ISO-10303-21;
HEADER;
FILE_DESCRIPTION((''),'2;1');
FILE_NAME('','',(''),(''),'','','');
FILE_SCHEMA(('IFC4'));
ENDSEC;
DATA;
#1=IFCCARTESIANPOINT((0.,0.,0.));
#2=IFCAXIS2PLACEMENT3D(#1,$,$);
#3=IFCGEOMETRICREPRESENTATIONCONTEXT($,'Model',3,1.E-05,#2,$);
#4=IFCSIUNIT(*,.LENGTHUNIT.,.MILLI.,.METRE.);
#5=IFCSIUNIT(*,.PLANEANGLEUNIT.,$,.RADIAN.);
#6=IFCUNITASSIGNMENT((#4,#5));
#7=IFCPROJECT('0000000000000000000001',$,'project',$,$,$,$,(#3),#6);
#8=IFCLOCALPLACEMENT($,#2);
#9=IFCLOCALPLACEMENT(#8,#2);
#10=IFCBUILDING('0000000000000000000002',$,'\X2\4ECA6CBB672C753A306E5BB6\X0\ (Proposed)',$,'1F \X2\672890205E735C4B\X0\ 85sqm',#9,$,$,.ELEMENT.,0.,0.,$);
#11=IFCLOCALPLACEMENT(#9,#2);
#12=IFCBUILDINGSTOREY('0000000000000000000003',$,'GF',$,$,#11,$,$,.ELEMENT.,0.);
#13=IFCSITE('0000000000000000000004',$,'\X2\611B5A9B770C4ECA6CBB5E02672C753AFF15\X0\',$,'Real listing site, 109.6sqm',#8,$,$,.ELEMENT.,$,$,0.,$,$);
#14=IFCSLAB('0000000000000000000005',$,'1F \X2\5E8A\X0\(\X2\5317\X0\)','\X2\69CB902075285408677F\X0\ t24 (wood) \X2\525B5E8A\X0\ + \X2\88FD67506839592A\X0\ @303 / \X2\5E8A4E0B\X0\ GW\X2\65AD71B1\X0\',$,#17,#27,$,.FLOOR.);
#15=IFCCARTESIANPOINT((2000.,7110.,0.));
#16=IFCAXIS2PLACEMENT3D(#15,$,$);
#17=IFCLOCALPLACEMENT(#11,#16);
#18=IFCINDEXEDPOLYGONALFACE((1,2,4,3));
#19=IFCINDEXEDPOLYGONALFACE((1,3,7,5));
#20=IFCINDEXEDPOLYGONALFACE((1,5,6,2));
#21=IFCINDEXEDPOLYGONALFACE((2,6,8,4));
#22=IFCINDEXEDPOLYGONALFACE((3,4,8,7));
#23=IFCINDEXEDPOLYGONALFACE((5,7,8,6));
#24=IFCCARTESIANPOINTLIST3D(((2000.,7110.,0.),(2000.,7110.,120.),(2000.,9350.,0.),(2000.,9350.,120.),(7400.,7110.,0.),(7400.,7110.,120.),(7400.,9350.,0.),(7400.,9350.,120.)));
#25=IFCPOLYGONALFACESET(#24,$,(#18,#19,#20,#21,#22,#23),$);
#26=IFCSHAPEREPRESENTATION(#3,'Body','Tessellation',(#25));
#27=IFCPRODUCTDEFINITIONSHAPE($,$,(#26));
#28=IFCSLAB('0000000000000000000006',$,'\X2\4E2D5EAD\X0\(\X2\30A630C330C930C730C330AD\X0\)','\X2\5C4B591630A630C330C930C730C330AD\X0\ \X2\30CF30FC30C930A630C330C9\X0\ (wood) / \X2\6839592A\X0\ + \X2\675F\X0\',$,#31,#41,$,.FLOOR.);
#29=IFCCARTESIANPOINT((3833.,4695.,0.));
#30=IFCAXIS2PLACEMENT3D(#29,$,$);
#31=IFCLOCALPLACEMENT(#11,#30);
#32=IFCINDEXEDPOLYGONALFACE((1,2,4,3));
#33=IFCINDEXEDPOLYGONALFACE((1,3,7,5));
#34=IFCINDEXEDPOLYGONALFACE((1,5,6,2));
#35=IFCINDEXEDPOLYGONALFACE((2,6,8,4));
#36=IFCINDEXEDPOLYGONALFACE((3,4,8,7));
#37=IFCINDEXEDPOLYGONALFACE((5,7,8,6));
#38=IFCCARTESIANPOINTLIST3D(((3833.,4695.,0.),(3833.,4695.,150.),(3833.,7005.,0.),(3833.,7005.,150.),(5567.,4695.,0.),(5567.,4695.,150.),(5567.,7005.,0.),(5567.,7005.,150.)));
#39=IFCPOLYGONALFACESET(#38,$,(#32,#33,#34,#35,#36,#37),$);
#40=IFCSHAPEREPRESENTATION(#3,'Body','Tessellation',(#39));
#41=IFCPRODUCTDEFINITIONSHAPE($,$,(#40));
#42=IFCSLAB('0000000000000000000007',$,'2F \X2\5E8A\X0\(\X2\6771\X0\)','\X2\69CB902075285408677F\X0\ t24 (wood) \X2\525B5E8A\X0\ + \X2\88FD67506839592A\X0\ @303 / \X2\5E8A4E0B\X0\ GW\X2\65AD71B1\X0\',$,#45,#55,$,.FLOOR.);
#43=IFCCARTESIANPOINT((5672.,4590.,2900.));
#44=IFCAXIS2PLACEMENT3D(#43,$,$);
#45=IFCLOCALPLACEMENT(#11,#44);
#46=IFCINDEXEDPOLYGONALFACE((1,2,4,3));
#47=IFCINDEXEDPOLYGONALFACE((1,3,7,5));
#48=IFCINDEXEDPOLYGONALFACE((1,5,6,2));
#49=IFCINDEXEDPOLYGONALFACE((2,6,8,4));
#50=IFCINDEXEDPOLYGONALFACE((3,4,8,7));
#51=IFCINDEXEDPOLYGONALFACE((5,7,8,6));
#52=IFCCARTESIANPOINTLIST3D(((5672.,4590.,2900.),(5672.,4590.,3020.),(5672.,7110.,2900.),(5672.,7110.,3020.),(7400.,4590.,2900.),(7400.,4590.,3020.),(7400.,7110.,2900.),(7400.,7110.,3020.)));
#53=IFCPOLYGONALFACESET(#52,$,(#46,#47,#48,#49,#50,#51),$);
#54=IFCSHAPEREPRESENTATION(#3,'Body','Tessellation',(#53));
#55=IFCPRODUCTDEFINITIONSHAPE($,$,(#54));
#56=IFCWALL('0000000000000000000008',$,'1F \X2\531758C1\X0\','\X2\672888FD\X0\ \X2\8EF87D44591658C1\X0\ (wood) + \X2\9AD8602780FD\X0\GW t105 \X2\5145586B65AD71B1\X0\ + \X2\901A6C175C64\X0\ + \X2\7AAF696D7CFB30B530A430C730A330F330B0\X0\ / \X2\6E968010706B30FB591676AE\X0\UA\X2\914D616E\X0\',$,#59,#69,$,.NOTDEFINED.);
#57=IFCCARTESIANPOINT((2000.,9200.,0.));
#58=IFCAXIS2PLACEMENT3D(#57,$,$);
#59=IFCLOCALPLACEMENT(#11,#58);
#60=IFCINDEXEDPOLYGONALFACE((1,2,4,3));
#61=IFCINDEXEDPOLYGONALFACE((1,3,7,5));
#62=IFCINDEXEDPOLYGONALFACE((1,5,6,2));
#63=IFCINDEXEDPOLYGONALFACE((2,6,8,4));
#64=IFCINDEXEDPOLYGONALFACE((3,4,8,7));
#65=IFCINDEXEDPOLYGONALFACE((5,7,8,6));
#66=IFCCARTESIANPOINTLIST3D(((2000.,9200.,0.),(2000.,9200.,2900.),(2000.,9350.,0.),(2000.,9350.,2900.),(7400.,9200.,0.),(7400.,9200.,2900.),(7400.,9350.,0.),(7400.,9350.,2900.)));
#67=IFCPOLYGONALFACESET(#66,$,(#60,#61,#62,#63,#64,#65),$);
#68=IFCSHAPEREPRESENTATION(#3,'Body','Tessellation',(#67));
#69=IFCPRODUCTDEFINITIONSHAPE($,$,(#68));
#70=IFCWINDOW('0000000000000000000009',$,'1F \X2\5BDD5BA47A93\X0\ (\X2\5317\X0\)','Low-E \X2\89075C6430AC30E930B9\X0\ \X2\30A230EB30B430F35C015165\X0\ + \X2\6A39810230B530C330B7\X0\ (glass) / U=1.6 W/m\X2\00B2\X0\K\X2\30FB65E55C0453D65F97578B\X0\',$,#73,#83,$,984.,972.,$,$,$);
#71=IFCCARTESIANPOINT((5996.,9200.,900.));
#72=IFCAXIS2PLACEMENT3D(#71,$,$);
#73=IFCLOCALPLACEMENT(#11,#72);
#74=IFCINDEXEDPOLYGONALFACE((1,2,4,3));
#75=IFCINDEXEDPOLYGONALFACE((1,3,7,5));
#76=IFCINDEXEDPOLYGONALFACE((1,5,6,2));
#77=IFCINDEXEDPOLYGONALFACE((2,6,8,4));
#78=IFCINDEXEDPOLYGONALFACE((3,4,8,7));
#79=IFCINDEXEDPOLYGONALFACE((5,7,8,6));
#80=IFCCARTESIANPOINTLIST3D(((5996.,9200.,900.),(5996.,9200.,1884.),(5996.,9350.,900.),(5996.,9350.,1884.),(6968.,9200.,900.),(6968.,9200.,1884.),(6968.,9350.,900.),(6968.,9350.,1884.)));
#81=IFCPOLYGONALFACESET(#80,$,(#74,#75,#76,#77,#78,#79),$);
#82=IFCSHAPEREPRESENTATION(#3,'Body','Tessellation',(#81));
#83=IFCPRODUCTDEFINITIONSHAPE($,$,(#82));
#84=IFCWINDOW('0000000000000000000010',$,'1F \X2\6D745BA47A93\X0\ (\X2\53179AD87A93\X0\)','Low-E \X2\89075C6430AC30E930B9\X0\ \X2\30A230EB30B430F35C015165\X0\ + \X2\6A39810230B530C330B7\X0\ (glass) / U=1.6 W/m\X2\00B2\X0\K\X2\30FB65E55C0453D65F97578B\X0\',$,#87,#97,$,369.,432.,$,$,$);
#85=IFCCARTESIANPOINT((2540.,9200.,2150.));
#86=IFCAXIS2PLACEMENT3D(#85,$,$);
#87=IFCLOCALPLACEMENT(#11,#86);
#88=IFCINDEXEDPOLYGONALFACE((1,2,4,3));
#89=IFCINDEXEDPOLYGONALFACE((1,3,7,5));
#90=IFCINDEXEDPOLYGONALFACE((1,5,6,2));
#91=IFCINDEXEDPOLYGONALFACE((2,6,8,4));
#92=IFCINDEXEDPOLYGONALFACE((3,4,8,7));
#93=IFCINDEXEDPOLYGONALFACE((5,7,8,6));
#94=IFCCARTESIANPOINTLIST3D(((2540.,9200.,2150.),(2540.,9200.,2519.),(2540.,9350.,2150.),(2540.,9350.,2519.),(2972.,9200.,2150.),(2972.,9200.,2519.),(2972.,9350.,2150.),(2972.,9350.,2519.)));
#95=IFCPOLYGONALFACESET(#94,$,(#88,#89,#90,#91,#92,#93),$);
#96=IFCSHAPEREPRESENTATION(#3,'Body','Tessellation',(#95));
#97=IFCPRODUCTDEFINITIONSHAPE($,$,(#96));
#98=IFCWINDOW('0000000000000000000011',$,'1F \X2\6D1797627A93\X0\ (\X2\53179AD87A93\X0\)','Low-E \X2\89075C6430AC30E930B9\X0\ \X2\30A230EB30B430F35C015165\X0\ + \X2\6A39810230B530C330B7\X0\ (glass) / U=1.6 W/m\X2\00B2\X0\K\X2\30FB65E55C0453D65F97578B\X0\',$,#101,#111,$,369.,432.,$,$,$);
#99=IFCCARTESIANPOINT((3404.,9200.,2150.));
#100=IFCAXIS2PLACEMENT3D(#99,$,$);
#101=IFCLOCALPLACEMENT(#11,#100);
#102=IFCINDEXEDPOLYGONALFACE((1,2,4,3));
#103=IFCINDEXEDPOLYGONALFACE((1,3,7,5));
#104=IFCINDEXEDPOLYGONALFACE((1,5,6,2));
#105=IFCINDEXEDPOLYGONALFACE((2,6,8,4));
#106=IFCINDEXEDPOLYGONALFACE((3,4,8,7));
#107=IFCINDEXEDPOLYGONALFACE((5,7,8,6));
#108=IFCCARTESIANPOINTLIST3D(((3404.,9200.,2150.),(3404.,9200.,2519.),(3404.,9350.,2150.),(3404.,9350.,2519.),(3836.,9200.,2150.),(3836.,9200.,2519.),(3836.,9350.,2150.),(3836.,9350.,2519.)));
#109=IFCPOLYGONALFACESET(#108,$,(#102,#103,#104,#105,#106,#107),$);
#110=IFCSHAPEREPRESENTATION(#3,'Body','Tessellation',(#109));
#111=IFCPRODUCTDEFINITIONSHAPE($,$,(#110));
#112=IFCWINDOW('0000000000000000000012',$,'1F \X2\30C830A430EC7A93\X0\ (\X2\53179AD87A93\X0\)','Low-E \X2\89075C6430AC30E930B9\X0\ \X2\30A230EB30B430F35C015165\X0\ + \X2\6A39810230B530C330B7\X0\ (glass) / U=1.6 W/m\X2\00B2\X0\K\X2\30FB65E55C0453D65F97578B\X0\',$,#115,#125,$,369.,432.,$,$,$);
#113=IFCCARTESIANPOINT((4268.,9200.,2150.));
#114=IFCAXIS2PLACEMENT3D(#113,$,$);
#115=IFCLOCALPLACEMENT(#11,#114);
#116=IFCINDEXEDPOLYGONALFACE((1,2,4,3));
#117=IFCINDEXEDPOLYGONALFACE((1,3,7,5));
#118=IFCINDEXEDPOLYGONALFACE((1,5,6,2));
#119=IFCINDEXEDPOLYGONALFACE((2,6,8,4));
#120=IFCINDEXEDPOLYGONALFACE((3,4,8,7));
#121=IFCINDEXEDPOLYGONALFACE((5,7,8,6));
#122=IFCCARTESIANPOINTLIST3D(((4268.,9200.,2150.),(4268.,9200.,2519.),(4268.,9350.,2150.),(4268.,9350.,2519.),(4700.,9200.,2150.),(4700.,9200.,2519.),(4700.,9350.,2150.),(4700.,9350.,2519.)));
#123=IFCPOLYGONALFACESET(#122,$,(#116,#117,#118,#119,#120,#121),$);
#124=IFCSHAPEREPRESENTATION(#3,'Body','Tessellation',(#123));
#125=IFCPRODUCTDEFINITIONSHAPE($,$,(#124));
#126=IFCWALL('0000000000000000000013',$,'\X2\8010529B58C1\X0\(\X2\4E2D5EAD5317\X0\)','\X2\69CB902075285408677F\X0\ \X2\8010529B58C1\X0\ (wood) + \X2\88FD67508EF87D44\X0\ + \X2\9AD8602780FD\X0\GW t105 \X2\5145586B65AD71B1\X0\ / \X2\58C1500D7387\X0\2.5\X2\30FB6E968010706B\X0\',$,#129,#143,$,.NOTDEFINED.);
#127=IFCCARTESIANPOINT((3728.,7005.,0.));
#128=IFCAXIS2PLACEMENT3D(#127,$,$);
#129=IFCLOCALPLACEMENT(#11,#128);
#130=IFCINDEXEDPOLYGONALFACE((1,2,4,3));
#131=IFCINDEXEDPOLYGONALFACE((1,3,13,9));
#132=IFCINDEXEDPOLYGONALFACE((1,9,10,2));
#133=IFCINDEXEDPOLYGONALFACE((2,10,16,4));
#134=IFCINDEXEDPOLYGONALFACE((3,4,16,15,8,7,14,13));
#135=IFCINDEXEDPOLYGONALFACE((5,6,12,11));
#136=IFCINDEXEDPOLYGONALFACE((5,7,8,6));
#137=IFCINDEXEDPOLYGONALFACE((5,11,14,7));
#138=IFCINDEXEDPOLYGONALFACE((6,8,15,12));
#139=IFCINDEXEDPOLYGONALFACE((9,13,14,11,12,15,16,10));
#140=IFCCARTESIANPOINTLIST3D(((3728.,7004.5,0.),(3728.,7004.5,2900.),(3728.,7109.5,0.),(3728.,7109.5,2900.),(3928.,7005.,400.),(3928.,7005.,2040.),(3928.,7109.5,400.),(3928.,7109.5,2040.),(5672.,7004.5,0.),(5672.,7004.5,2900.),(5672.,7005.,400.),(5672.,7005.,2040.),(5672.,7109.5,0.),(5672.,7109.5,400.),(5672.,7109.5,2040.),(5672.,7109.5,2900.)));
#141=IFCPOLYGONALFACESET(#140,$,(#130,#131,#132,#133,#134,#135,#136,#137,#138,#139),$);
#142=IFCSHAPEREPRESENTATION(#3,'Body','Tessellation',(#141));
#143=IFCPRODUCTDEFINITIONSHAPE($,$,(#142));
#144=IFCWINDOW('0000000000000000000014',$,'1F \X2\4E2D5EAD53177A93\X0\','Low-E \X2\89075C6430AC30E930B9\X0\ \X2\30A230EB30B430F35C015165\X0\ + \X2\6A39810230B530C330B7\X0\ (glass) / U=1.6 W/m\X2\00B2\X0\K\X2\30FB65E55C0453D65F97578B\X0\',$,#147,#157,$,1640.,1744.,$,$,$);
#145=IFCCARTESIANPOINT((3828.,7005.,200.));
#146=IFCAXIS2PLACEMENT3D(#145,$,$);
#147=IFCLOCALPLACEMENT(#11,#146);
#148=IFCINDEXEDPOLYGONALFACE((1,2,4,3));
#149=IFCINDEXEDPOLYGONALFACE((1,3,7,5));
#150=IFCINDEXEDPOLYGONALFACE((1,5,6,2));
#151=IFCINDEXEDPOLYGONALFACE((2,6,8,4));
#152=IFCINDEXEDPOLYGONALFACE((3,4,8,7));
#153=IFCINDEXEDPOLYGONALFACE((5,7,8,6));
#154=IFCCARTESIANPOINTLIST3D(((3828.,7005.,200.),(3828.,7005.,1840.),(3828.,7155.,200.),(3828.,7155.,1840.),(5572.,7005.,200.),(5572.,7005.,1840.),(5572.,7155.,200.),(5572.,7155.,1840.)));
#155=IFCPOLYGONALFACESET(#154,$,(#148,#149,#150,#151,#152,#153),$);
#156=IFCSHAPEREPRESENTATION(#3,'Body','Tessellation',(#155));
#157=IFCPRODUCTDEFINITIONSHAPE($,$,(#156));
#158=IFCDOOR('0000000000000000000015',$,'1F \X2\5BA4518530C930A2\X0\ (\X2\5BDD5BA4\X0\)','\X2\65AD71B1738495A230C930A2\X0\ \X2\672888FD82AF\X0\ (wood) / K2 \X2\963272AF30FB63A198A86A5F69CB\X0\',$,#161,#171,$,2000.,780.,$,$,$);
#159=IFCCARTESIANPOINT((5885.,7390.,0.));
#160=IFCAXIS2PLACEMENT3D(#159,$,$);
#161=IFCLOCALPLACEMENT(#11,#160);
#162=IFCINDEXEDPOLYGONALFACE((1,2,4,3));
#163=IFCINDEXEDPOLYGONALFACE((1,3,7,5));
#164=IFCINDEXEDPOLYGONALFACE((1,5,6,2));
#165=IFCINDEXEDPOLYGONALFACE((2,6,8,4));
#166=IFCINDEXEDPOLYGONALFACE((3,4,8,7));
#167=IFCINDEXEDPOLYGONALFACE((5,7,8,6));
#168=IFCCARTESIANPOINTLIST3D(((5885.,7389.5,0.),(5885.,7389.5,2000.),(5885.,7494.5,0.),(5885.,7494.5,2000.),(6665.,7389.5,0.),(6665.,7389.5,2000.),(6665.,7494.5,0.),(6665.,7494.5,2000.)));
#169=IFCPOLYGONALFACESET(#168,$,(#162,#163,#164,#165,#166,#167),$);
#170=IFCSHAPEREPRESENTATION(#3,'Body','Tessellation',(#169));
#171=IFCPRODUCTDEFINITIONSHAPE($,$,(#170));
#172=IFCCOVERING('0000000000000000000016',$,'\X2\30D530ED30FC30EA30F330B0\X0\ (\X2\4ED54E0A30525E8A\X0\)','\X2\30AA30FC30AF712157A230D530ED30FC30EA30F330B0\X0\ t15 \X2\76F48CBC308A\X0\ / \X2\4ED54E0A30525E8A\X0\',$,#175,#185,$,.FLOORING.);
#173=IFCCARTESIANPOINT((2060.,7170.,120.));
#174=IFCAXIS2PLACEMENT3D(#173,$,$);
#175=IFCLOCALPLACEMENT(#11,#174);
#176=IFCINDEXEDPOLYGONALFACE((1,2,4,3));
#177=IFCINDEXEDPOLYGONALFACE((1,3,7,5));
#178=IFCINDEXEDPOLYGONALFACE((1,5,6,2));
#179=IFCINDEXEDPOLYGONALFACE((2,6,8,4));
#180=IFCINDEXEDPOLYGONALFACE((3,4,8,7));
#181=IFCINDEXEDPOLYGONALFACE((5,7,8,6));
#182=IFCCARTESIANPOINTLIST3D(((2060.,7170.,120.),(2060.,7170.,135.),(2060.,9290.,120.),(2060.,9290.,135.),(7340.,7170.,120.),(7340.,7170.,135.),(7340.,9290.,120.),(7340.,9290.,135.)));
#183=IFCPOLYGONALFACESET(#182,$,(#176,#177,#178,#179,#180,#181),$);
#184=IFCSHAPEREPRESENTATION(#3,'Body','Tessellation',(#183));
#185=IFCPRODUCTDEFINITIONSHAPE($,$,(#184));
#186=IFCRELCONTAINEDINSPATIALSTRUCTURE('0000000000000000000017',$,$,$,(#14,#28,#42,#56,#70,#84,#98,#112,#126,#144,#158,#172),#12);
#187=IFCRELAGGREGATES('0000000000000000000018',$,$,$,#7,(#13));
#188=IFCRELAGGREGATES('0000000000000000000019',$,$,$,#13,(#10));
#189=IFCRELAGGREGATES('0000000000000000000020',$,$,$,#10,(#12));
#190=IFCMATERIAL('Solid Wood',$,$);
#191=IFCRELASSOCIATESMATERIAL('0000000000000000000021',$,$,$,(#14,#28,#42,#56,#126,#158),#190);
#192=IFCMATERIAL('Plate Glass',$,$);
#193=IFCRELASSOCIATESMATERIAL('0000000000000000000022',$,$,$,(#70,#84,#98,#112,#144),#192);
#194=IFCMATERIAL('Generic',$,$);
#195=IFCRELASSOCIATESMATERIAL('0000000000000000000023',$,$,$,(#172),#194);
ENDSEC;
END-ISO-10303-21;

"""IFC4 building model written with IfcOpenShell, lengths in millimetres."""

from ifc_helpers import new_model, si_unit, frame, frame_2d, origin, place, context, project, spatial, rectangle, extrude, material, element, fill, save


model = new_model("IFC4")

# Units and contexts
model_context = context("Model", 3, precision=1e-05, world=origin())
ifc_project = project(units=[si_unit("LENGTHUNIT", "METRE", prefix="MILLI"), si_unit("PLANEANGLEUNIT", "RADIAN")], contexts=[model_context])

# Site, building, storey
site_placement = place(None, origin())
site = spatial("IfcSite", under=ifc_project, at=site_placement, Name="愛媛県今治市本町５", ObjectType="Real listing site, 109.6sqm", CompositionType="ELEMENT", RefElevation=0.0)
building_placement = place(site_placement, origin())
building = spatial("IfcBuilding", under=site, at=building_placement, Name="今治本町の家 (Proposed)", ObjectType="1F 木造平屋 85sqm", CompositionType="ELEMENT", ElevationOfRefHeight=0.0, ElevationOfTerrain=0.0)
storey_placement = place(building_placement, origin())
storey = spatial("IfcBuildingStorey", under=building, at=storey_placement, Name="GF", CompositionType="ELEMENT", Elevation=0.0)

# Slabs
ifc_material_1 = material(Name="Solid Wood")
slab_1_placement = place(storey_placement, frame((2000.0, 7110.0, 0.0)))
element("IfcSlab", 1, at=slab_1_placement, inside=storey, material=ifc_material_1, Name="1F 床(北)", Description="構造用合板 t24 (wood) 剛床 + 製材根太 @303 / 床下 GW断熱", PredefinedType="FLOOR", context=model_context, shape_type="SweptSolid", body=[
    extrude(rectangle(XDim=5400.0, YDim=2240.0, at=frame_2d((2700.0, 1120.0))), frame((2000.0, 7110.0, 0.0)), (0.0, 0.0, 1.0), 120.0),
])
slab_2_placement = place(storey_placement, frame((3833.0, 4695.0, 0.0)))
element("IfcSlab", 2, at=slab_2_placement, inside=storey, material=ifc_material_1, Name="中庭(ウッドデッキ)", Description="屋外ウッドデッキ ハードウッド (wood) / 根太 + 束", PredefinedType="FLOOR", context=model_context, shape_type="SweptSolid", body=[
    extrude(rectangle(XDim=1734.0, YDim=2310.0, at=frame_2d((867.0, 1155.0))), frame((3833.0, 4695.0, 0.0)), (0.0, 0.0, 1.0), 150.0),
])
slab_3_placement = place(storey_placement, frame((5672.0, 4590.0, 2900.0)))
element("IfcSlab", 3, at=slab_3_placement, inside=storey, material=ifc_material_1, Name="2F 床(東)", Description="構造用合板 t24 (wood) 剛床 + 製材根太 @303 / 床下 GW断熱", PredefinedType="FLOOR", context=model_context, shape_type="SweptSolid", body=[
    extrude(rectangle(XDim=1728.0, YDim=2520.0, at=frame_2d((864.0, 1260.0))), frame((5672.0, 4590.0, 2900.0)), (0.0, 0.0, 1.0), 120.0),
])

# Wall, openings, windows
wall_1_placement = place(storey_placement, frame((2000.0, 9200.0, 0.0)))
wall_1 = element("IfcWall", 4, at=wall_1_placement, inside=storey, material=ifc_material_1, Name="1F 北壁", Description="木製 軸組外壁 (wood) + 高性能GW t105 充填断熱 + 通気層 + 窯業系サイディング / 準耐火・外皮UA配慮", PredefinedType="NOTDEFINED", context=model_context, shape_type="SweptSolid", body=[
    extrude(rectangle(XDim=5400.0, YDim=150.0, at=frame_2d((2700.0, 75.0))), frame((2000.0, 9200.0, 0.0)), (0.0, 0.0, 1.0), 2900.0),
])
opening_1_placement = place(storey_placement, frame((5996.0, 9200.0, 900.0)))
opening_1 = element("IfcOpeningElement", 5, at=opening_1_placement, cuts=wall_1, PredefinedType="NOTDEFINED", context=model_context, shape_type="SweptSolid", body=[
    extrude(rectangle(XDim=972.0, YDim=150.0, at=frame_2d((486.0, 75.0))), frame((5996.0, 9200.0, 900.0)), (0.0, 0.0, 1.0), 984.0),
])
opening_2_placement = place(storey_placement, frame((2540.0, 9200.0, 2150.0)))
opening_2 = element("IfcOpeningElement", 6, at=opening_2_placement, cuts=wall_1, PredefinedType="NOTDEFINED", context=model_context, shape_type="SweptSolid", body=[
    extrude(rectangle(XDim=432.0, YDim=150.0, at=frame_2d((216.0, 75.0))), frame((2540.0, 9200.0, 2150.0)), (0.0, 0.0, 1.0), 369.0),
])
opening_3_placement = place(storey_placement, frame((3404.0, 9200.0, 2150.0)))
opening_3 = element("IfcOpeningElement", 7, at=opening_3_placement, cuts=wall_1, PredefinedType="NOTDEFINED", context=model_context, shape_type="SweptSolid", body=[
    extrude(rectangle(XDim=432.0, YDim=150.0, at=frame_2d((216.0, 75.0))), frame((3404.0, 9200.0, 2150.0)), (0.0, 0.0, 1.0), 369.0),
])
opening_4_placement = place(storey_placement, frame((4268.0, 9200.0, 2150.0)))
opening_4 = element("IfcOpeningElement", 8, at=opening_4_placement, cuts=wall_1, PredefinedType="NOTDEFINED", context=model_context, shape_type="SweptSolid", body=[
    extrude(rectangle(XDim=432.0, YDim=150.0, at=frame_2d((216.0, 75.0))), frame((4268.0, 9200.0, 2150.0)), (0.0, 0.0, 1.0), 369.0),
])
ifc_material_2 = material(Name="Plate Glass")
window_1_placement = place(storey_placement, frame((5996.0, 9200.0, 900.0)))
window_1 = element("IfcWindow", 9, at=window_1_placement, inside=storey, material=ifc_material_2, Name="1F 寝室窓 (北)", Description="Low-E 複層ガラス アルゴン封入 + 樹脂サッシ (glass) / U=1.6 W/m²K・日射取得型", OverallHeight=984.0, OverallWidth=972.0, context=model_context, shape_type="SweptSolid", body=[
    extrude(rectangle(XDim=972.0, YDim=150.0, at=frame_2d((486.0, 75.0))), frame((5996.0, 9200.0, 900.0)), (0.0, 0.0, 1.0), 984.0),
])
fill(opening_1, window_1)
window_2_placement = place(storey_placement, frame((2540.0, 9200.0, 2150.0)))
window_2 = element("IfcWindow", 10, at=window_2_placement, inside=storey, material=ifc_material_2, Name="1F 浴室窓 (北高窓)", Description="Low-E 複層ガラス アルゴン封入 + 樹脂サッシ (glass) / U=1.6 W/m²K・日射取得型", OverallHeight=369.0, OverallWidth=432.0, context=model_context, shape_type="SweptSolid", body=[
    extrude(rectangle(XDim=432.0, YDim=150.0, at=frame_2d((216.0, 75.0))), frame((2540.0, 9200.0, 2150.0)), (0.0, 0.0, 1.0), 369.0),
])
fill(opening_2, window_2)
window_3_placement = place(storey_placement, frame((3404.0, 9200.0, 2150.0)))
window_3 = element("IfcWindow", 11, at=window_3_placement, inside=storey, material=ifc_material_2, Name="1F 洗面窓 (北高窓)", Description="Low-E 複層ガラス アルゴン封入 + 樹脂サッシ (glass) / U=1.6 W/m²K・日射取得型", OverallHeight=369.0, OverallWidth=432.0, context=model_context, shape_type="SweptSolid", body=[
    extrude(rectangle(XDim=432.0, YDim=150.0, at=frame_2d((216.0, 75.0))), frame((3404.0, 9200.0, 2150.0)), (0.0, 0.0, 1.0), 369.0),
])
fill(opening_3, window_3)
window_4_placement = place(storey_placement, frame((4268.0, 9200.0, 2150.0)))
window_4 = element("IfcWindow", 12, at=window_4_placement, inside=storey, material=ifc_material_2, Name="1F トイレ窓 (北高窓)", Description="Low-E 複層ガラス アルゴン封入 + 樹脂サッシ (glass) / U=1.6 W/m²K・日射取得型", OverallHeight=369.0, OverallWidth=432.0, context=model_context, shape_type="SweptSolid", body=[
    extrude(rectangle(XDim=432.0, YDim=150.0, at=frame_2d((216.0, 75.0))), frame((4268.0, 9200.0, 2150.0)), (0.0, 0.0, 1.0), 369.0),
])
fill(opening_4, window_4)

# Wall, opening, window
wall_2_placement = place(storey_placement, frame((3728.0, 7005.0, 0.0)))
wall_2 = element("IfcWall", 13, at=wall_2_placement, inside=storey, material=ifc_material_1, Name="耐力壁(中庭北)", Description="構造用合板 耐力壁 (wood) + 製材軸組 + 高性能GW t105 充填断熱 / 壁倍率2.5・準耐火", PredefinedType="NOTDEFINED", context=model_context, shape_type="SweptSolid", body=[
    extrude(rectangle(XDim=1944.0, YDim=105.0, at=frame_2d((972.0, 52.0))), frame((3728.0, 7005.0, 0.0)), (0.0, 0.0, 1.0), 2900.0),
])
opening_5_placement = place(storey_placement, frame((3828.0, 7005.0, 200.0)))
opening_5 = element("IfcOpeningElement", 14, at=opening_5_placement, cuts=wall_2, PredefinedType="NOTDEFINED", context=model_context, shape_type="SweptSolid", body=[
    extrude(rectangle(XDim=1744.0, YDim=150.0, at=frame_2d((872.0, 75.0))), frame((3828.0, 7005.0, 200.0)), (0.0, 0.0, 1.0), 1640.0),
])
window_5_placement = place(storey_placement, frame((3828.0, 7005.0, 200.0)))
window_5 = element("IfcWindow", 15, at=window_5_placement, inside=storey, material=ifc_material_2, Name="1F 中庭北窓", Description="Low-E 複層ガラス アルゴン封入 + 樹脂サッシ (glass) / U=1.6 W/m²K・日射取得型", OverallHeight=1640.0, OverallWidth=1744.0, context=model_context, shape_type="SweptSolid", body=[
    extrude(rectangle(XDim=1744.0, YDim=150.0, at=frame_2d((872.0, 75.0))), frame((3828.0, 7005.0, 200.0)), (0.0, 0.0, 1.0), 1640.0),
])
fill(opening_5, window_5)

# Door
door_1_placement = place(storey_placement, frame((5885.0, 7390.0, 0.0)))
element("IfcDoor", 16, at=door_1_placement, inside=storey, material=ifc_material_1, Name="1F 室内ドア (寝室)", Description="断熱玄関ドア 木製芯 (wood) / K2 防犯・採風機構", OverallHeight=2000.0, OverallWidth=780.0, context=model_context, shape_type="SweptSolid", body=[
    extrude(rectangle(XDim=780.0, YDim=105.0, at=frame_2d((390.0, 52.0))), frame((5885.0, 7390.0, 0.0)), (0.0, 0.0, 1.0), 2000.0),
])

# Covering
ifc_material_3 = material(Name="Generic")
covering_1_placement = place(storey_placement, frame((2060.0, 7170.0, 120.0)))
element("IfcCovering", 17, at=covering_1_placement, inside=storey, material=ifc_material_3, Name="フローリング (仕上げ床)", Description="オーク無垢フローリング t15 直貼り / 仕上げ床", PredefinedType="FLOORING", context=model_context, shape_type="SweptSolid", body=[
    extrude(rectangle(XDim=5280.0, YDim=2120.0, at=frame_2d((2640.0, 1060.0))), frame((2060.0, 7170.0, 120.0)), (0.0, 0.0, 1.0), 15.0),
])

save(model, "model.ifc")
